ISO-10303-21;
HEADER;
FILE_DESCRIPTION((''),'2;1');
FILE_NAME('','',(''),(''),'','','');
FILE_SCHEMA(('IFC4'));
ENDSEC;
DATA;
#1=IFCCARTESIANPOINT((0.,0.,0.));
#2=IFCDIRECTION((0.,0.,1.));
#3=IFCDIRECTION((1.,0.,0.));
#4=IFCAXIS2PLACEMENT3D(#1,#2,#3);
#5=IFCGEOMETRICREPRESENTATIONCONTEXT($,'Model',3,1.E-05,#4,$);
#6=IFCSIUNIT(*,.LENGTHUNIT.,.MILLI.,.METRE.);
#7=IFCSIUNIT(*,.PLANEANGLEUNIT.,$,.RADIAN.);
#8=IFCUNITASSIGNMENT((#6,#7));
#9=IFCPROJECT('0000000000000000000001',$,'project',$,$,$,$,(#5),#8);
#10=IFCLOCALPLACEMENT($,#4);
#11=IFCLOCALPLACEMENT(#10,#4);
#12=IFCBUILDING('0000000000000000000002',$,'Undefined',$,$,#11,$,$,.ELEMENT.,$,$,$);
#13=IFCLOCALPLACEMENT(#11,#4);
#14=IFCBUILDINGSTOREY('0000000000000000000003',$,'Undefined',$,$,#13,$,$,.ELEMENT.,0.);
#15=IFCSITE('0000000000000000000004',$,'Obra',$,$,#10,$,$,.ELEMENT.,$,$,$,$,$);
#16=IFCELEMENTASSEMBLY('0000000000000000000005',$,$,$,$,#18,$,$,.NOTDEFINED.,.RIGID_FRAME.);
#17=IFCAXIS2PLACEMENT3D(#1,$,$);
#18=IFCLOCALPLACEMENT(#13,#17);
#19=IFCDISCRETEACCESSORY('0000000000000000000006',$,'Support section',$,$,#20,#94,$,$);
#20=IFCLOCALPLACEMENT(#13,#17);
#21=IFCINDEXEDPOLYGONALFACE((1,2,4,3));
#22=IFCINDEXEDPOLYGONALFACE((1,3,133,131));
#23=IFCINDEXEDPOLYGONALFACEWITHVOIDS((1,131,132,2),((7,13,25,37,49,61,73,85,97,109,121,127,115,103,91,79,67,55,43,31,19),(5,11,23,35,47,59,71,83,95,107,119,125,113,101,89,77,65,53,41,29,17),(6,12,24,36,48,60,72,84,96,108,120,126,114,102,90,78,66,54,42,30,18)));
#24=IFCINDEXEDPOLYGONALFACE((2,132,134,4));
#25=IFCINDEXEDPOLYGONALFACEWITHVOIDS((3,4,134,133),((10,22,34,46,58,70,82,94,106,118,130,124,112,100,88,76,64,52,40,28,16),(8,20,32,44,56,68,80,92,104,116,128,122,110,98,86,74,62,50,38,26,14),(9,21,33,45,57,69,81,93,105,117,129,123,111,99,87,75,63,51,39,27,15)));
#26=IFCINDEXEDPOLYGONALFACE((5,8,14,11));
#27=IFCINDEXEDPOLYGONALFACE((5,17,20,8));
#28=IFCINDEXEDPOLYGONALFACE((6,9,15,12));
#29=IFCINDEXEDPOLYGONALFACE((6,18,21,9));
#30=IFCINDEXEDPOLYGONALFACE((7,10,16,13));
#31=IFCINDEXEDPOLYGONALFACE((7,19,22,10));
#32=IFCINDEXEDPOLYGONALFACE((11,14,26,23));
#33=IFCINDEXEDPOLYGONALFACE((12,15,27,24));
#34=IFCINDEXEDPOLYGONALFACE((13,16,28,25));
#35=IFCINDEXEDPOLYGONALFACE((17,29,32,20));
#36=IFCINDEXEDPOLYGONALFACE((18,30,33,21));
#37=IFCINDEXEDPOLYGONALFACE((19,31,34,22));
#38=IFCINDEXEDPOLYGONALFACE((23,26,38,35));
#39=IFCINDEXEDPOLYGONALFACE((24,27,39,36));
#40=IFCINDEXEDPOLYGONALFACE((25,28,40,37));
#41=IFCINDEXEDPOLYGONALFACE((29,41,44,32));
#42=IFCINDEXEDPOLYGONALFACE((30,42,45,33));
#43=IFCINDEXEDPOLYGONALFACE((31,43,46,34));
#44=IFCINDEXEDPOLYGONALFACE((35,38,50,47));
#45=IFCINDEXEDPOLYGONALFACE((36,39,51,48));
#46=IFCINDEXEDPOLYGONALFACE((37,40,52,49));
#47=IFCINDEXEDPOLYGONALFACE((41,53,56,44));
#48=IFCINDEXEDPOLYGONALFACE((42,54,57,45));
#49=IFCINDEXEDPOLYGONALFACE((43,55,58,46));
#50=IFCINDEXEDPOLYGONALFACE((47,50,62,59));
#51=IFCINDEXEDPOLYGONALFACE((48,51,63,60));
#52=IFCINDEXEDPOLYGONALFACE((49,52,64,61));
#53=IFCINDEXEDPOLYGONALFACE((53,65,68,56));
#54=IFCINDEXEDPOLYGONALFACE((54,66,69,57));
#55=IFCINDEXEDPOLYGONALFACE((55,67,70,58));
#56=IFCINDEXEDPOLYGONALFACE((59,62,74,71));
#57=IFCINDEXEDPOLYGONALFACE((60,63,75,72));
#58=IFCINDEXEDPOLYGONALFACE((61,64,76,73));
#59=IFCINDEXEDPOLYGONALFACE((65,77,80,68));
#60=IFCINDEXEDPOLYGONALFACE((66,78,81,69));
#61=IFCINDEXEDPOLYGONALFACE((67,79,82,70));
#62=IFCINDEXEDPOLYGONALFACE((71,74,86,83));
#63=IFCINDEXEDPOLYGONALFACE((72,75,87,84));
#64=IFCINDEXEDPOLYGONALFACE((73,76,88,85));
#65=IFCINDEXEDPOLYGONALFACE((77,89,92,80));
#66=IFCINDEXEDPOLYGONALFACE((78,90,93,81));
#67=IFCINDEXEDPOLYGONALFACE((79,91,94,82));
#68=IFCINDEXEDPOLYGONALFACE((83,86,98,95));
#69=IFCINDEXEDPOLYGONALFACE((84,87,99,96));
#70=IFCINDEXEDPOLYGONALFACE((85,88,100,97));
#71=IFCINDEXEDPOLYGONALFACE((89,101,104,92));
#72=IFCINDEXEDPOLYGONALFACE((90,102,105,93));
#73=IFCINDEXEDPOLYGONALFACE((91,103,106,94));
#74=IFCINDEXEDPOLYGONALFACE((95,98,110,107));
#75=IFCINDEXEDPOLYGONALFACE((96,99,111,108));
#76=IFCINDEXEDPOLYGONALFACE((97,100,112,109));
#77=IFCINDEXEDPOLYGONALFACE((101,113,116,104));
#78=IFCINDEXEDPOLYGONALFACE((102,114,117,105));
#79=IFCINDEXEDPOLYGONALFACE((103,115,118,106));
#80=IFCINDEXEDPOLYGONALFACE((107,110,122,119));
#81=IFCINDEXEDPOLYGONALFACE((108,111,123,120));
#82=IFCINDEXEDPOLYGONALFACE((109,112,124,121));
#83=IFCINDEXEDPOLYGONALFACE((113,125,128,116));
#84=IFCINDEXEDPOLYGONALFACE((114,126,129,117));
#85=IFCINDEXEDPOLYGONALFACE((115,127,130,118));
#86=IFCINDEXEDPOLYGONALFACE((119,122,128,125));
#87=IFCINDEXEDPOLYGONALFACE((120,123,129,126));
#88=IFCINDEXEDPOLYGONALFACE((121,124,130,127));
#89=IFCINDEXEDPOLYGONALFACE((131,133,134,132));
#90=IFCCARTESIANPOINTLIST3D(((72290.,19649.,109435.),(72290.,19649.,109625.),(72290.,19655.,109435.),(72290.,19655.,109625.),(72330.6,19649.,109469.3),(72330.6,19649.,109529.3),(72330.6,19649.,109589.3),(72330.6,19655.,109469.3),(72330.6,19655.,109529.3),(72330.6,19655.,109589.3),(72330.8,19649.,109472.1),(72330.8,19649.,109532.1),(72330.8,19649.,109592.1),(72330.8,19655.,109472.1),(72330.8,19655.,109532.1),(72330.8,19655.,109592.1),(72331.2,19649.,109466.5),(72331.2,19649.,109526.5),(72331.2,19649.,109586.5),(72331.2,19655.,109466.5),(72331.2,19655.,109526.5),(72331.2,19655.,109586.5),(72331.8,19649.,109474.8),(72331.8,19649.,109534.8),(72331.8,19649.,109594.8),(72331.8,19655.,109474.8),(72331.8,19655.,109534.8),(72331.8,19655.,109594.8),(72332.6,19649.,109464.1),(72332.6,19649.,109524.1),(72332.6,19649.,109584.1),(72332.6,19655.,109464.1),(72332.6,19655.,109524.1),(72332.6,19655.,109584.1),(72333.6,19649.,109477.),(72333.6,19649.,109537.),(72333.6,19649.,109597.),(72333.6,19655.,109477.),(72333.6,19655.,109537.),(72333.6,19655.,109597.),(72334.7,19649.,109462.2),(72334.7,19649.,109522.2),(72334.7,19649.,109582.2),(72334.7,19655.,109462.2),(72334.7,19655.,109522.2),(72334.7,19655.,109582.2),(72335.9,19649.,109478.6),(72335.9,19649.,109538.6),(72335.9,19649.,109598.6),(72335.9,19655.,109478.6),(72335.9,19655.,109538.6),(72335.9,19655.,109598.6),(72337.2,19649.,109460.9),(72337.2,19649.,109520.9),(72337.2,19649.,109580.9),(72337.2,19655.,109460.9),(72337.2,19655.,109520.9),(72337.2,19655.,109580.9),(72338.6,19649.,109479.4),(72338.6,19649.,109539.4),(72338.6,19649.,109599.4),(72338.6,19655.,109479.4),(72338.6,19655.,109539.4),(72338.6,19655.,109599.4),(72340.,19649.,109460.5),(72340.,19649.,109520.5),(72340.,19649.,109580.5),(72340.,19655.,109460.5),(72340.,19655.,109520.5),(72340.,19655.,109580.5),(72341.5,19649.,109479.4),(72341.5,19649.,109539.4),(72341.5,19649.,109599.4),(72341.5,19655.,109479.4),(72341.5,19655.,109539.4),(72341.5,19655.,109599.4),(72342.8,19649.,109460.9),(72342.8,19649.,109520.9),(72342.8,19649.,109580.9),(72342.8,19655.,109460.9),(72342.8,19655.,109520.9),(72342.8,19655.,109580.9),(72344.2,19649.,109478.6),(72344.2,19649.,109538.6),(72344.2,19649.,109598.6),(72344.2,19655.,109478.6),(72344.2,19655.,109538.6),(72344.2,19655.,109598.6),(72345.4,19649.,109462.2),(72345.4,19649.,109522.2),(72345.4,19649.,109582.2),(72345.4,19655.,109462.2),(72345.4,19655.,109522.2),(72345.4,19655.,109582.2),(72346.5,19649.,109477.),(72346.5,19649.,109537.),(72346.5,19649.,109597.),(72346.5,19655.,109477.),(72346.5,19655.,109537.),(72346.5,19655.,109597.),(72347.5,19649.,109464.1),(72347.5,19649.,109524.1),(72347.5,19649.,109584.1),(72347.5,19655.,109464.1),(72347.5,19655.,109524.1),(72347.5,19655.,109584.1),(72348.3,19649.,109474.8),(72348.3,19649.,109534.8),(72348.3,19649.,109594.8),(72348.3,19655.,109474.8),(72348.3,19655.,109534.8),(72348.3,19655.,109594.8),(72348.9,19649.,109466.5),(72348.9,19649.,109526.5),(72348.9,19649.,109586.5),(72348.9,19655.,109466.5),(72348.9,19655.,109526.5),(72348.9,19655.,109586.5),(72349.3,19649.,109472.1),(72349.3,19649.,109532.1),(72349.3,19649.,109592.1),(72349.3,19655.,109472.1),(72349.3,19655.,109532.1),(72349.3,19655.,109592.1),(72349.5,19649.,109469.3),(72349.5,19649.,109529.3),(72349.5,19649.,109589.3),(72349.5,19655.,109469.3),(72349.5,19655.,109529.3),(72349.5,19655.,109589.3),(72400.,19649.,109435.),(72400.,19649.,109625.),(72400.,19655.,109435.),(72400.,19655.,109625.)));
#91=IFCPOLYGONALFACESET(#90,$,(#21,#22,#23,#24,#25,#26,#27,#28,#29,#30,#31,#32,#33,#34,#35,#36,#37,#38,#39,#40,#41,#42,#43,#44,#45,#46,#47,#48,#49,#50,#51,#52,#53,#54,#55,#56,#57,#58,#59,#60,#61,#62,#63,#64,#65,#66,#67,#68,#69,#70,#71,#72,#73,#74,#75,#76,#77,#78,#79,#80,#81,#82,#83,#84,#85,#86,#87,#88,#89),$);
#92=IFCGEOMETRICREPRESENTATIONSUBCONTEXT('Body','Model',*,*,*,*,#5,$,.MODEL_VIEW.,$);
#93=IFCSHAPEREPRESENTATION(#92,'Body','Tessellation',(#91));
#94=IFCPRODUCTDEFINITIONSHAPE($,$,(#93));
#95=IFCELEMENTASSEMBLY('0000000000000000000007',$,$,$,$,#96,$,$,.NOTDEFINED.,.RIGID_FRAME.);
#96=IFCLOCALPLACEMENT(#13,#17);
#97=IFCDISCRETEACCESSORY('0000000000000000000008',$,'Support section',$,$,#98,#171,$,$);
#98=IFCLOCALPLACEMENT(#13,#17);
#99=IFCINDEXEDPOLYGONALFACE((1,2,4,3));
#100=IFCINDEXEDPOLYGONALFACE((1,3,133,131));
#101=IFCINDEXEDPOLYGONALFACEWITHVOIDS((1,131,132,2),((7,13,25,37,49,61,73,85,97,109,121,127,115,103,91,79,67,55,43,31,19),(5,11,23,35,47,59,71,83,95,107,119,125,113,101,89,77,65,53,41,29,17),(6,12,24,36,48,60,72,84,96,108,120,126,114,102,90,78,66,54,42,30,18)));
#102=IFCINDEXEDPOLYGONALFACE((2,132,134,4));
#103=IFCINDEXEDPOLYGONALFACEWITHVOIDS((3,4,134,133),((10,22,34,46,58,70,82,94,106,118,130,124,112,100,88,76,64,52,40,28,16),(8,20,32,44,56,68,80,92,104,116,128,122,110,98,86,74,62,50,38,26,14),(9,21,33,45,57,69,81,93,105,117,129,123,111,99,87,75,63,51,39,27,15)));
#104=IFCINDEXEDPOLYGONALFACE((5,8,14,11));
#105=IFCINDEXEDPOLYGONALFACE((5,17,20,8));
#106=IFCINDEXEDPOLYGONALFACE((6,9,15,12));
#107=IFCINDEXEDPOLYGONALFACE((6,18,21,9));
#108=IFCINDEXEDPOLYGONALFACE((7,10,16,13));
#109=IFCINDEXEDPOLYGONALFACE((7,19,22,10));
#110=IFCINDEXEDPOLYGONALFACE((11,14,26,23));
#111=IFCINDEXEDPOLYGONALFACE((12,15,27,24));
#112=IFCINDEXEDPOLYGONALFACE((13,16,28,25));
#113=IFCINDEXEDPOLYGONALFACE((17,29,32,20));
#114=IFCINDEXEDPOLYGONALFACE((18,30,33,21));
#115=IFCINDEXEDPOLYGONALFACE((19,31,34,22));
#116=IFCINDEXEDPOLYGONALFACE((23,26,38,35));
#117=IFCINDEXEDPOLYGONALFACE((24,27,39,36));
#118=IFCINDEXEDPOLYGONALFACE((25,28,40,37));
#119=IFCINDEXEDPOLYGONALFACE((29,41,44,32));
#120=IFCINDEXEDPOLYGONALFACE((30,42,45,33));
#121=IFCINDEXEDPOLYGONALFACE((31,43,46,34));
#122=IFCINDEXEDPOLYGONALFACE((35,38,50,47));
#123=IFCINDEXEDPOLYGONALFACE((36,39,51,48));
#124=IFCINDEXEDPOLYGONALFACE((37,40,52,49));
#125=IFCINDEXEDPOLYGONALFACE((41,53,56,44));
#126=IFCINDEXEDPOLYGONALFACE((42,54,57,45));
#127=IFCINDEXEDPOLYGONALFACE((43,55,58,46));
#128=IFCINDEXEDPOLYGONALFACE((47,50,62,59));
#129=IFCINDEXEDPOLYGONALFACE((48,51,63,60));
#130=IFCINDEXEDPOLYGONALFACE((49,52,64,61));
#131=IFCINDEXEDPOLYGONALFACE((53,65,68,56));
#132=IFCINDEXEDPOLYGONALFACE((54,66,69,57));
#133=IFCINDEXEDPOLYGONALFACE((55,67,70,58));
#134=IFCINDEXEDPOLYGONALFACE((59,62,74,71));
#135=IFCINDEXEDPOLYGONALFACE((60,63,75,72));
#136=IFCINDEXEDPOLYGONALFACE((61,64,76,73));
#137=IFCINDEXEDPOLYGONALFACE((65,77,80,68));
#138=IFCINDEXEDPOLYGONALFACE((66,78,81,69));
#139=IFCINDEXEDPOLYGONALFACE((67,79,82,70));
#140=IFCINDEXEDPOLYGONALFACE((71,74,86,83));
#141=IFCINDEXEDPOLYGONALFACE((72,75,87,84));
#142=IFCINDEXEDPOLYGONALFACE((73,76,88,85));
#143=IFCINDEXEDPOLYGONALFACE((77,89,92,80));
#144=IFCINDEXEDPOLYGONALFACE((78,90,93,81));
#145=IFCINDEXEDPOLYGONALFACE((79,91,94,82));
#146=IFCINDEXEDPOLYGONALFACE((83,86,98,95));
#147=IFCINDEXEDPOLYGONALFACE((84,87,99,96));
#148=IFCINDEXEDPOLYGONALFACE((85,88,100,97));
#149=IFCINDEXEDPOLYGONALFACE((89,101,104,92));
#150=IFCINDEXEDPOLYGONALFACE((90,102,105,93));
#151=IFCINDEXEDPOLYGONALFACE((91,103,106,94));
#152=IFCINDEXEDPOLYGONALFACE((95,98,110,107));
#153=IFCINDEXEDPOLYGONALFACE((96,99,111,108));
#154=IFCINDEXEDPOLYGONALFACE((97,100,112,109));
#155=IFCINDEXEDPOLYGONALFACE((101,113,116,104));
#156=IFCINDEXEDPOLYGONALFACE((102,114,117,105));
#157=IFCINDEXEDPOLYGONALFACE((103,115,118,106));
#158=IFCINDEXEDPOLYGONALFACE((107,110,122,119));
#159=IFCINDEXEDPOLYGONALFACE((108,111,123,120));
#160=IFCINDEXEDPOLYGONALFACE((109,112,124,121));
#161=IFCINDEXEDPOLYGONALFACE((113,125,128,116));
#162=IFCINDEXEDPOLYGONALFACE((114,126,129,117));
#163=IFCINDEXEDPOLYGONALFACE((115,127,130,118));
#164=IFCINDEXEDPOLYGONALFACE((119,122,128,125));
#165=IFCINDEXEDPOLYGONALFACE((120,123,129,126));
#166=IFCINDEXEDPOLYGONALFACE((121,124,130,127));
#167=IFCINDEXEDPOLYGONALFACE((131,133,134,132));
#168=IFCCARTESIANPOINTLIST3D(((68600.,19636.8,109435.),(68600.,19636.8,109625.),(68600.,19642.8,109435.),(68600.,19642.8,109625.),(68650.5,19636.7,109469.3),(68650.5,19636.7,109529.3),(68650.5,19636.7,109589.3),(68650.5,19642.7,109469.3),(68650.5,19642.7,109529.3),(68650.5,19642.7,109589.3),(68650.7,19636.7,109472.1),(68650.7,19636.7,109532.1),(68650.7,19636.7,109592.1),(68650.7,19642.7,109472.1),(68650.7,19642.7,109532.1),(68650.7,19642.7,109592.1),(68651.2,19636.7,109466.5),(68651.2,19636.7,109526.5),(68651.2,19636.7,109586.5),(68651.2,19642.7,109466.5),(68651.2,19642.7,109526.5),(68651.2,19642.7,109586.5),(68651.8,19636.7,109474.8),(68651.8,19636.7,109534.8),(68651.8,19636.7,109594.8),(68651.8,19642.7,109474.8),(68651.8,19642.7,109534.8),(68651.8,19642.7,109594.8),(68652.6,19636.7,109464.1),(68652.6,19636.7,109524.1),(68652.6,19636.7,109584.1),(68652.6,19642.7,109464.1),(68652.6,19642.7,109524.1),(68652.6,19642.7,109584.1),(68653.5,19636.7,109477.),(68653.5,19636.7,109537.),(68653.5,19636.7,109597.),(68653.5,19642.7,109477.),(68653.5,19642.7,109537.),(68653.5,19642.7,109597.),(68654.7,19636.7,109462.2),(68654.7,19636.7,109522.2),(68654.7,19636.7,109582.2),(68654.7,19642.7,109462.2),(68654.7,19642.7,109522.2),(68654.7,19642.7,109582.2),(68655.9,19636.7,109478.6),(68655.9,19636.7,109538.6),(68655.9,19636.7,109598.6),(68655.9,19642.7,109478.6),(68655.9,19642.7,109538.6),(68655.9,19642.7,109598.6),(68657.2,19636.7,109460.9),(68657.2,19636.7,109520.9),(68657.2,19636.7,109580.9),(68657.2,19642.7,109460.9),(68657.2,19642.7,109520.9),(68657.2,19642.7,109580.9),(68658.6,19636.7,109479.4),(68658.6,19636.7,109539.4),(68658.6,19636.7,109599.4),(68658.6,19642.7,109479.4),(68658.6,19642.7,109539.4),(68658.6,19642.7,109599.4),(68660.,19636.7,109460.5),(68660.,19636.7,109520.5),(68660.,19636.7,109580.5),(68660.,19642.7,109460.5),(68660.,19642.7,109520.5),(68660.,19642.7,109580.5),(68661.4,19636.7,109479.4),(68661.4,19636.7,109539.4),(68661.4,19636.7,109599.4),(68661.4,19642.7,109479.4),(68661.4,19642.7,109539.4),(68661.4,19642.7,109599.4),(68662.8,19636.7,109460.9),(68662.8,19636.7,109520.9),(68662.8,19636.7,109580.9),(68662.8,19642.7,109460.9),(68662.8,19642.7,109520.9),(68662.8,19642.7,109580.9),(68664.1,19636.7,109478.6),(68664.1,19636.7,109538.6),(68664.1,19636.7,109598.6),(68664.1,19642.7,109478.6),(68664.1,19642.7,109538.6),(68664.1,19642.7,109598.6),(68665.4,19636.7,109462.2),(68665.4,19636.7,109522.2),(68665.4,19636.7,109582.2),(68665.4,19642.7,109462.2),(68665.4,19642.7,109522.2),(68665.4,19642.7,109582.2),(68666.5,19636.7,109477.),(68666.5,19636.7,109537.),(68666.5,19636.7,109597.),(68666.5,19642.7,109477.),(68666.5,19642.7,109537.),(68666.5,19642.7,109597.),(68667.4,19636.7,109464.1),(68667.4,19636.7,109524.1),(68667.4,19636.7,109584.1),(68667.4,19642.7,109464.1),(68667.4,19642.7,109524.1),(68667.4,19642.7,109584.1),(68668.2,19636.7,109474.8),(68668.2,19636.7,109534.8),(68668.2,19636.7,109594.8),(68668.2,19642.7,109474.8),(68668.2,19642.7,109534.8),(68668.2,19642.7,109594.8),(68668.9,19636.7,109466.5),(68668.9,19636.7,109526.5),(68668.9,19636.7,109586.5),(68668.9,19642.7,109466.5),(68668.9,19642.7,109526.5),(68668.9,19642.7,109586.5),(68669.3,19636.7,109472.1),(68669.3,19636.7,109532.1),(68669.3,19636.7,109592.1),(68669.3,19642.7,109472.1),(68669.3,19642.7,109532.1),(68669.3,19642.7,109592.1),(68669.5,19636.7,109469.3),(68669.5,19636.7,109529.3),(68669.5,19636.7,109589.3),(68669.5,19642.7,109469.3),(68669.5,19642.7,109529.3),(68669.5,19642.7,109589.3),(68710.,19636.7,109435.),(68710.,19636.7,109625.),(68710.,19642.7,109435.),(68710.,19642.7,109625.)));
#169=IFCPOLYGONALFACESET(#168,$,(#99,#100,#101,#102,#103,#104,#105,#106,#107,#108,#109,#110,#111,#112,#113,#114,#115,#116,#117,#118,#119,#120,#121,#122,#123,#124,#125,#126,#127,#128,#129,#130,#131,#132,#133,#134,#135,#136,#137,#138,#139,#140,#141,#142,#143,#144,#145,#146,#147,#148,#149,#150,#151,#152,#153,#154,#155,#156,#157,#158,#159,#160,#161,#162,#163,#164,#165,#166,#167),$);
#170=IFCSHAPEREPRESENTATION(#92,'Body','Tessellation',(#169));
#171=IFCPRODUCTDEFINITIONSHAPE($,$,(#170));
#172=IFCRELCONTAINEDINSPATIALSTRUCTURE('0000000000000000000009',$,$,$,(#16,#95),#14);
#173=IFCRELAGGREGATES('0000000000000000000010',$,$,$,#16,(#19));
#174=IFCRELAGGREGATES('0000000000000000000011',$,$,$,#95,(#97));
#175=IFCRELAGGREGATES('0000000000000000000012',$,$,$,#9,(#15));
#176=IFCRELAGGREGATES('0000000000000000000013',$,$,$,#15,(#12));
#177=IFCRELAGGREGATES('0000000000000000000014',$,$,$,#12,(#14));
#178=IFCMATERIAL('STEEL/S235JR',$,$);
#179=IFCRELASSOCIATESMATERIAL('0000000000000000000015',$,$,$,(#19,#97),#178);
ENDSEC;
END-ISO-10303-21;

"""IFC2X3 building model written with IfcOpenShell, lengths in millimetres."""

from ifc_helpers import new_model, si_unit, frame, origin_with_axes, origin_2d_with_axis, place, context, subcontext, project, spatial, rectangle, circle, extrude, source, transform, mapped, material, element, aggregate, save


model = new_model("IFC2X3")

# Units and contexts
model_context = context("Model", 3, precision=1e-05, world=origin_with_axes())
body_context = subcontext(model_context, "Body", "Model", "MODEL_VIEW")
ifc_project = project(units=[si_unit("LENGTHUNIT", "METRE", prefix="MILLI"), si_unit("PLANEANGLEUNIT", "RADIAN")], contexts=[model_context])

# Site, building, storey
site_placement = place(None, origin_with_axes())
site = spatial("IfcSite", under=ifc_project, at=site_placement, Name="Obra", CompositionType="ELEMENT")
building_placement = place(site_placement, origin_with_axes())
building = spatial("IfcBuilding", under=site, at=building_placement, Name="Undefined", CompositionType="ELEMENT")
storey_placement = place(building_placement, origin_with_axes())
storey = spatial("IfcBuildingStorey", under=building, at=storey_placement, Name="Undefined", CompositionType="ELEMENT", Elevation=0.0)

# Shared definitions
ifc_material_1 = material(Name="STEEL/S235JR")

# Element assemblies, discrete accessories, openings
shared_shape_1 = source(origin_with_axes(), body_context, "Body", "SweptSolid", [
    extrude(circle(Radius=9.5, at=origin_2d_with_axis()), frame((0.0, -9.2, 0.0), z_axis=(0.0, 1.0, 0.0), x_axis=(1.0, 0.0, 0.0)), (0.0, 0.0, 1.0), 6.2),
])
assembly_1_placement = place(storey_placement, origin_with_axes())
assembly_1 = element("IfcElementAssembly", 1, at=assembly_1_placement, inside=storey, AssemblyPlace="NOTDEFINED", PredefinedType="RIGID_FRAME")
discrete_accessory_1_placement = place(assembly_1_placement, frame((72345.0, 19652.0, 109435.0), z_axis=(0.0, 0.0, 1.0), x_axis=(1.0, -0.000126, 0.0)))
discrete_accessory_1 = element("IfcDiscreteAccessory", 2, at=discrete_accessory_1_placement, material=ifc_material_1, Name="Support section", context=body_context, shape_type="SweptSolid", body=[
    extrude(rectangle(XDim=6.0, YDim=110.0, at=origin_2d_with_axis()), frame((0.0, 0.0, 190.0), z_axis=(0.0, 0.0, -1.0), x_axis=(0.0, 1.0, 0.0)), (0.0, 0.0, 1.0), 190.0),
])
opening_1_placement = place(assembly_1_placement, frame((72390.0, 19645.9, 109650.0), z_axis=(-1.0, 0.000126, 0.0), x_axis=(0.0, 0.0, -1.0)))
element("IfcOpeningElement", 3, at=opening_1_placement, cuts=discrete_accessory_1, ObjectType="Opening", context=body_context, shape_type="MappedRepresentation", body=[
    mapped(shared_shape_1, transform((60.0, 0.0, 50.0))),
    mapped(shared_shape_1, transform((120.0, 0.0, 50.0))),
    mapped(shared_shape_1, transform((180.0, 0.0, 50.0))),
])
aggregate(assembly_1, [discrete_accessory_1])
assembly_2_placement = place(storey_placement, origin_with_axes())
assembly_2 = element("IfcElementAssembly", 4, at=assembly_2_placement, inside=storey, AssemblyPlace="NOTDEFINED", PredefinedType="RIGID_FRAME")
discrete_accessory_2_placement = place(assembly_2_placement, frame((68655.0, 19639.7, 109435.0), z_axis=(0.0, 0.0, 1.0), x_axis=(-1.0, 0.000126, 0.0)))
discrete_accessory_2 = element("IfcDiscreteAccessory", 5, at=discrete_accessory_2_placement, material=ifc_material_1, Name="Support section", context=body_context, shape_type="SweptSolid", body=[
    extrude(rectangle(XDim=6.0, YDim=110.0, at=origin_2d_with_axis()), frame((0.0, 0.0, 190.0), z_axis=(0.0, 0.0, -1.0), x_axis=(0.0, 1.0, 0.0)), (0.0, 0.0, 1.0), 190.0),
])
opening_2_placement = place(assembly_2_placement, frame((68610.0, 19645.8, 109650.0), z_axis=(1.0, -0.000126, 0.0), x_axis=(0.0, 0.0, -1.0)))
element("IfcOpeningElement", 6, at=opening_2_placement, cuts=discrete_accessory_2, ObjectType="Opening", context=body_context, shape_type="MappedRepresentation", body=[
    mapped(shared_shape_1, transform((60.0, 0.0, 50.0))),
    mapped(shared_shape_1, transform((120.0, 0.0, 50.0))),
    mapped(shared_shape_1, transform((180.0, 0.0, 50.0))),
])
aggregate(assembly_2, [discrete_accessory_2])

save(model, "model.ifc")
